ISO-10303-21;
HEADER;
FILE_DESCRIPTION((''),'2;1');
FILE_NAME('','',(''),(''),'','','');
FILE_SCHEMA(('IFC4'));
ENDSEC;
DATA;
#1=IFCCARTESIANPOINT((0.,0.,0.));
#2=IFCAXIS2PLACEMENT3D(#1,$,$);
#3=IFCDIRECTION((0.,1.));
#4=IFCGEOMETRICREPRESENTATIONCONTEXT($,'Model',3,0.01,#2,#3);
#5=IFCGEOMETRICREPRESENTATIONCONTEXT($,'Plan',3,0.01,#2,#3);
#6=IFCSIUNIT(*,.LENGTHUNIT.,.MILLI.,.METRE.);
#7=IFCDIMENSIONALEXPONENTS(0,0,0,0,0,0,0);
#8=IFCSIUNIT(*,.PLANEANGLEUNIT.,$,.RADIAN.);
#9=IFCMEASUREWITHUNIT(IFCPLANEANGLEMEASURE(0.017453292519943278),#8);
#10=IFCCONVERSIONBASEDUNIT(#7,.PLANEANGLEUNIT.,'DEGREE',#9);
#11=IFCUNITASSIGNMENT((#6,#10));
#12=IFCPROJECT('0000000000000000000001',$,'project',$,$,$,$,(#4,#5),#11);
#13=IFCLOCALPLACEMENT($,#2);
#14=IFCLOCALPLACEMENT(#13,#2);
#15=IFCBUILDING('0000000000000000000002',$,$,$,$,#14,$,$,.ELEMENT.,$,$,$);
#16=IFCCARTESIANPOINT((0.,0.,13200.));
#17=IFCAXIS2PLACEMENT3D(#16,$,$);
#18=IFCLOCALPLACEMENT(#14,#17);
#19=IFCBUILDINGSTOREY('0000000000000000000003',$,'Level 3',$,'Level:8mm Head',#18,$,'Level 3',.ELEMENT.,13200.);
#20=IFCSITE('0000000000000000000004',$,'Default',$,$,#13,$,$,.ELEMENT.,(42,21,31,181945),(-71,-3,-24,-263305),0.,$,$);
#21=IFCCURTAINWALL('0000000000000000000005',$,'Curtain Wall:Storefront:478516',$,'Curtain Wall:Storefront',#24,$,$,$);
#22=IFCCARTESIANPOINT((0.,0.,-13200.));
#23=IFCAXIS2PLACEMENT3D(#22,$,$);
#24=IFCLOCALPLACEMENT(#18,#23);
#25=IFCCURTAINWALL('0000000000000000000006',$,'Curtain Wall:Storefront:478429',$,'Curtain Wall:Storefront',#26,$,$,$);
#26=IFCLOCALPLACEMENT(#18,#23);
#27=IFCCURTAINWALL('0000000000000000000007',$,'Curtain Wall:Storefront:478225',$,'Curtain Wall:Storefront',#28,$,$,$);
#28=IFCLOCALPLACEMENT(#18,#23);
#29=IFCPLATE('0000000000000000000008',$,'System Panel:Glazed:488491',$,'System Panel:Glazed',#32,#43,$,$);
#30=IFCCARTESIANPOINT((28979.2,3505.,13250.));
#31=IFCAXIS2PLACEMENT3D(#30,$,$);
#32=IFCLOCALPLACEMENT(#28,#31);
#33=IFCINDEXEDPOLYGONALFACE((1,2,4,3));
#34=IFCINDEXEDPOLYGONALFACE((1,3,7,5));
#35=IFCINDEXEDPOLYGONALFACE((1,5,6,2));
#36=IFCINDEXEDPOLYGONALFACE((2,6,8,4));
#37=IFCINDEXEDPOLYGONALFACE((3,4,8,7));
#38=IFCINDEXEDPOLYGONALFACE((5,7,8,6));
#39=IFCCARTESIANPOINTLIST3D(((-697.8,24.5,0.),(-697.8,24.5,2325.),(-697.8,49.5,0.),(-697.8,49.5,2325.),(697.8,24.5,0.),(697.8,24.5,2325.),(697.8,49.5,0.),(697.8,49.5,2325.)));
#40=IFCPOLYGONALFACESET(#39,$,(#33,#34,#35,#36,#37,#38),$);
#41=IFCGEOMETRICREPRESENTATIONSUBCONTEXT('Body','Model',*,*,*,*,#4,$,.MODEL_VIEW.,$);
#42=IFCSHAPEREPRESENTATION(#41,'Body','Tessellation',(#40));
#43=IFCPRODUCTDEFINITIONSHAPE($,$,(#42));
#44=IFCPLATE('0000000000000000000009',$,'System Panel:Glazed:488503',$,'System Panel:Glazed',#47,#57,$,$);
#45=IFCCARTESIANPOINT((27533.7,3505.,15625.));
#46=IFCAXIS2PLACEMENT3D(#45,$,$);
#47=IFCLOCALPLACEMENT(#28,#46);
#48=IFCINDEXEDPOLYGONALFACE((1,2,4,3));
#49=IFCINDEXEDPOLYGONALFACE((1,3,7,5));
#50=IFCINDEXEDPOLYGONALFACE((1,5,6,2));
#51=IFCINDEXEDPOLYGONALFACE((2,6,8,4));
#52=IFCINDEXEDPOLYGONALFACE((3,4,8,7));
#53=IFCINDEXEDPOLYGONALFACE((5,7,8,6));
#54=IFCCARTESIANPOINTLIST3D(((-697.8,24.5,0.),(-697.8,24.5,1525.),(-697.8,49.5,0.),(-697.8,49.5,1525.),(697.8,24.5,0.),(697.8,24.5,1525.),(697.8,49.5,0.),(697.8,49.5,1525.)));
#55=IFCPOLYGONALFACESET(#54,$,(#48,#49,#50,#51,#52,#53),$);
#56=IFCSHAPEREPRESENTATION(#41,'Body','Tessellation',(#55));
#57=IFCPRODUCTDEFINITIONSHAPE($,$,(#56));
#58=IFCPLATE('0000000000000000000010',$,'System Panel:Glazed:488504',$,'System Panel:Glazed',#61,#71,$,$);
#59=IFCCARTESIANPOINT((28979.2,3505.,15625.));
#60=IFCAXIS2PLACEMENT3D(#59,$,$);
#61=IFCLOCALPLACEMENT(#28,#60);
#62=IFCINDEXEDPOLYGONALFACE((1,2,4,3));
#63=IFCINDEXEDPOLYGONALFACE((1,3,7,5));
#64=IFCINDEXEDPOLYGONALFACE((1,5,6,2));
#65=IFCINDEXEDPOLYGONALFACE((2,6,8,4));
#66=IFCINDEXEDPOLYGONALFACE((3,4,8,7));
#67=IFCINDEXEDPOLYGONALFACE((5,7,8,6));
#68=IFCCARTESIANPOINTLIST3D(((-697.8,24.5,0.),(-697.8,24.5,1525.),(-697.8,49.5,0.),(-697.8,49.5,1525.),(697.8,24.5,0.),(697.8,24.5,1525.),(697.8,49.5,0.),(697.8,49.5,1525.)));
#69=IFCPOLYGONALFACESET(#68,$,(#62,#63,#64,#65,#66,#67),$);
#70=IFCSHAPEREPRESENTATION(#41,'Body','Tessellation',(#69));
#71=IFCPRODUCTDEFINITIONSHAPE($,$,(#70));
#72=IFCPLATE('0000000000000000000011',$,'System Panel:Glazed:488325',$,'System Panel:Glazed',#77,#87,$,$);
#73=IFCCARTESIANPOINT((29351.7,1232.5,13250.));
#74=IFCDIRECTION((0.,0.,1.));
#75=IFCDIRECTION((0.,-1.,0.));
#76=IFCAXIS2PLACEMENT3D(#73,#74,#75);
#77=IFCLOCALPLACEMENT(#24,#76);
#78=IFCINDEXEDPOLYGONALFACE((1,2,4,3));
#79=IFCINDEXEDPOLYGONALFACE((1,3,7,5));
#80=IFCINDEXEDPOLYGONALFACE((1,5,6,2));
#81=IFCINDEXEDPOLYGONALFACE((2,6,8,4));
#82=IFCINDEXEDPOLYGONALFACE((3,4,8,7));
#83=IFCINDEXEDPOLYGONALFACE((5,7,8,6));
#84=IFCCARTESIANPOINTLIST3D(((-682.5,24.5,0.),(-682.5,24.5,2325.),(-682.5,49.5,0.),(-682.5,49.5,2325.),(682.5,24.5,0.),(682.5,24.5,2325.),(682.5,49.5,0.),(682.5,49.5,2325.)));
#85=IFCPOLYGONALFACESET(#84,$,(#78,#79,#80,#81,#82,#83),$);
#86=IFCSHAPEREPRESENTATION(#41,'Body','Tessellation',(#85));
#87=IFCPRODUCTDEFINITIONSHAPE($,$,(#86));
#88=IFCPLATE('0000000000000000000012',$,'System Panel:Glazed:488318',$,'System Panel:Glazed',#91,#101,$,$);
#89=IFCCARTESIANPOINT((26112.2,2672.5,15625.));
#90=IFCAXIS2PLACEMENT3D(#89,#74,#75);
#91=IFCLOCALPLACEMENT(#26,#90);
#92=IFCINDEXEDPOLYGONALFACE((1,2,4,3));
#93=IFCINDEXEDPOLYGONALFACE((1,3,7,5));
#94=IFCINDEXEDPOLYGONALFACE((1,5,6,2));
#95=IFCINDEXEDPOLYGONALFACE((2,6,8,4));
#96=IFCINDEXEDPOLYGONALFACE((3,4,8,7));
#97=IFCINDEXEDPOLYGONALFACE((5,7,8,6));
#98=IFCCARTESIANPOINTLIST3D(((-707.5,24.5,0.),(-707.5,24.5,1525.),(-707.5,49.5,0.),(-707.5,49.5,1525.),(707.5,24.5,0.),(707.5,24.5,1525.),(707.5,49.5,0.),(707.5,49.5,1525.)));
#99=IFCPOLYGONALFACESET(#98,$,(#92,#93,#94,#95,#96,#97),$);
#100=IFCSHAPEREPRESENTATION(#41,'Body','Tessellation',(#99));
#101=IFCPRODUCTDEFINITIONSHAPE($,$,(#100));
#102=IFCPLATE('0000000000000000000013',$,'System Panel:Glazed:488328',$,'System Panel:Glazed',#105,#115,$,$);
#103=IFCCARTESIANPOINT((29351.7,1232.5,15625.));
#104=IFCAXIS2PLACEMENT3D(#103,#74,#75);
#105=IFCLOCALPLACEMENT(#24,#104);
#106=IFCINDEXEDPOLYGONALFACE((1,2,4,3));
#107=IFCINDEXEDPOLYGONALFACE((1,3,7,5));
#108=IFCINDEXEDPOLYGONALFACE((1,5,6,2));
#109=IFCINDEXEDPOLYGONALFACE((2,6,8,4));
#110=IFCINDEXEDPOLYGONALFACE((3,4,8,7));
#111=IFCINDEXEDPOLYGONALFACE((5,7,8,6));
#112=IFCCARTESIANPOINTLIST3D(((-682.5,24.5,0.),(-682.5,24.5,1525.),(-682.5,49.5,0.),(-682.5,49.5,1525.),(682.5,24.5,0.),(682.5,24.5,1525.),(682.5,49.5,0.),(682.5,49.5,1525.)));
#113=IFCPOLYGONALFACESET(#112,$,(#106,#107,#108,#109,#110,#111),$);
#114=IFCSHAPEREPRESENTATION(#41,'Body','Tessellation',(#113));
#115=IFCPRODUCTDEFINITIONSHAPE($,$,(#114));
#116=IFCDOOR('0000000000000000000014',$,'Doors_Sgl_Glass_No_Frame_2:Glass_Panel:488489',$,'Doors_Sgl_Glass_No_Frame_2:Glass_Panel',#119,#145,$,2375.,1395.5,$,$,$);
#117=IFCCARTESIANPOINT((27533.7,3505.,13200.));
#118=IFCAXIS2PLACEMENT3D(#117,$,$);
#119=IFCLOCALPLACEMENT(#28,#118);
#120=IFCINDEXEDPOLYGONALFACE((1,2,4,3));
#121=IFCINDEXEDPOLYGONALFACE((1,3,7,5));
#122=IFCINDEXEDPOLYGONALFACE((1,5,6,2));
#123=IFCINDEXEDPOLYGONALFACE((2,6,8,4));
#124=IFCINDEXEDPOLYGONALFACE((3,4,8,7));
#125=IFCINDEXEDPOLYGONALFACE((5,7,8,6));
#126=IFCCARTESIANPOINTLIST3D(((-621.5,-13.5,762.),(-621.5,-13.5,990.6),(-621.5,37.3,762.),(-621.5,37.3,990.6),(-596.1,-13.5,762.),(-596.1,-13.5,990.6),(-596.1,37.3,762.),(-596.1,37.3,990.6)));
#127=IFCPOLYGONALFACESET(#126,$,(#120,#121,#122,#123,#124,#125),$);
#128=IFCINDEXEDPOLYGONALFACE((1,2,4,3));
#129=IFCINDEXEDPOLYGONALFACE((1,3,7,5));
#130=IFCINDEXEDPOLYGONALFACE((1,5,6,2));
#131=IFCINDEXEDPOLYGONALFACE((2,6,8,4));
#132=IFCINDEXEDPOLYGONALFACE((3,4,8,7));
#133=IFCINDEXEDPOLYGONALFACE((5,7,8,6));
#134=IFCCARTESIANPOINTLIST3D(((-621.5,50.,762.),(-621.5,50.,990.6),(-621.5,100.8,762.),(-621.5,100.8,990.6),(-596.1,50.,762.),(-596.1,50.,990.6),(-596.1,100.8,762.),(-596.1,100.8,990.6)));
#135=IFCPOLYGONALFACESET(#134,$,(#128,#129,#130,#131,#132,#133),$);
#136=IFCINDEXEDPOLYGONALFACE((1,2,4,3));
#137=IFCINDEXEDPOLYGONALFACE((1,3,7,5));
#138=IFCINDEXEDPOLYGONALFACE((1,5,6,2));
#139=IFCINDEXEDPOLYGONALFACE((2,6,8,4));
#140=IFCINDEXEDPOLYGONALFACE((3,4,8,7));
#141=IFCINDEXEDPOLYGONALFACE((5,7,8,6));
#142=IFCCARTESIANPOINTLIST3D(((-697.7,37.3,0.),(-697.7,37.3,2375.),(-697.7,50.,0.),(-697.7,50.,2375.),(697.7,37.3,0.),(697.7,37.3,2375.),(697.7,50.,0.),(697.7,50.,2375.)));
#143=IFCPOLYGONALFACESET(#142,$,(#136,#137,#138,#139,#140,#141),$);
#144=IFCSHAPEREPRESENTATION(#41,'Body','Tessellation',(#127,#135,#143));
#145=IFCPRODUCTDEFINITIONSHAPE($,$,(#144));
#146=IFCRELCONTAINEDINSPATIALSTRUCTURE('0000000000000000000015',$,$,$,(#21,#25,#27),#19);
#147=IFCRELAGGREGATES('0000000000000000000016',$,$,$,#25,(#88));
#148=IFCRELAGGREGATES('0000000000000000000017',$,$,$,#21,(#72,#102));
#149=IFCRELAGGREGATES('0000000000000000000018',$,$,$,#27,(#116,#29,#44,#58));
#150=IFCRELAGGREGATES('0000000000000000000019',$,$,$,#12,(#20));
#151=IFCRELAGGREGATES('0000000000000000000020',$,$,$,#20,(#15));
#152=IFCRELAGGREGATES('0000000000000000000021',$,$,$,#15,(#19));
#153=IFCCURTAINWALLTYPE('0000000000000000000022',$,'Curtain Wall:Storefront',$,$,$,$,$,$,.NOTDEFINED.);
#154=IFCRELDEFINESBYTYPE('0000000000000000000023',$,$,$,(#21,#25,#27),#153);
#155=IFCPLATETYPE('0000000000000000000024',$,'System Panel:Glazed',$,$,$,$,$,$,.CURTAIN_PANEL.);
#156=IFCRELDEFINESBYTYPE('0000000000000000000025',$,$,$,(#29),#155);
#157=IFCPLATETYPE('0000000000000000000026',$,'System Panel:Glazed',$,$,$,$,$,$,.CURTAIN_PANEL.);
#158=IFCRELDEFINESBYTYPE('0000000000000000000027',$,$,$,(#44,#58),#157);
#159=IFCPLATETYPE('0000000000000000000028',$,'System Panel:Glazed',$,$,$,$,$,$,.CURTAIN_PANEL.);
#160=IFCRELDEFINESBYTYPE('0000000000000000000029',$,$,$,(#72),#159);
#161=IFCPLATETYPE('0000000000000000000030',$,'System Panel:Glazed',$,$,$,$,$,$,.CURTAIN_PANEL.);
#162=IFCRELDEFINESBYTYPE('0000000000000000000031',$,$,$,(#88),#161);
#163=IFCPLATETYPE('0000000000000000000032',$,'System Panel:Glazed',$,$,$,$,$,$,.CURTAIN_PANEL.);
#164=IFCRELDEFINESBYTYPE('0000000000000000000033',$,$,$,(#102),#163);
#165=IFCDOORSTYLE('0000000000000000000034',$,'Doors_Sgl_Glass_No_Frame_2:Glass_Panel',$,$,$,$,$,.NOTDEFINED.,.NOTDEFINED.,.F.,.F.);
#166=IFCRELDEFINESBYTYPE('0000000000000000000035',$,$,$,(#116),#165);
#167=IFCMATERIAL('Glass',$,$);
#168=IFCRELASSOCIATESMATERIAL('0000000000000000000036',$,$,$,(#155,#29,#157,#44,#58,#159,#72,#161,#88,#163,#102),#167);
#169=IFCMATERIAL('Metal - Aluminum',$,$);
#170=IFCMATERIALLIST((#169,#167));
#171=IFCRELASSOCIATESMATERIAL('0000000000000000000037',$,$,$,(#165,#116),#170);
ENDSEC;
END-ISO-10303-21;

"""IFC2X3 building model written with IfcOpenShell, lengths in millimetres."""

from ifc_helpers import new_model, entity, si_unit, converted_unit, direction, frame, frame_2d, origin, origin_2d_with_axis, place, context, subcontext, project, spatial, rectangle, extrude, source, transform, mapped, material, material_list, type_object, type_shapes, element, aggregate, save


model = new_model("IFC2X3")

# Units and contexts
model_context = context("Model", 3, precision=0.01, world=origin(), true_north=direction((0.0, 1.0)))
plan_context = context("Plan", 3, precision=0.01, world=origin(), true_north=direction((0.0, 1.0)))
body_context = subcontext(model_context, "Body", "Model", "MODEL_VIEW")
ifc_project = project(units=[si_unit("LENGTHUNIT", "METRE", prefix="MILLI"), converted_unit("PLANEANGLEUNIT", "DEGREE", entity("IfcPlaneAngleMeasure", 0.017453292519943278), si_unit("PLANEANGLEUNIT", "RADIAN"), dimensions=[0, 0, 0, 0, 0, 0, 0])], contexts=[model_context, plan_context])

# Site, building, storey
site_placement = place(None, origin())
site = spatial("IfcSite", under=ifc_project, at=site_placement, Name="Default", CompositionType="ELEMENT", RefLatitude=(42, 21, 31, 181945), RefLongitude=(-71, -3, -24, -263305), RefElevation=0.0)
building_placement = place(site_placement, origin())
building = spatial("IfcBuilding", under=site, at=building_placement, CompositionType="ELEMENT")
storey_placement = place(building_placement, frame((0.0, 0.0, 13200.0)))
storey = spatial("IfcBuildingStorey", under=building, at=storey_placement, Name="Level 3", ObjectType="Level:8mm Head", LongName="Level 3", CompositionType="ELEMENT", Elevation=13200.0)

# Curtain walls
curtain_wall_type = type_object("IfcCurtainWallType", Name="Curtain Wall:Storefront", PredefinedType="NOTDEFINED")
curtain_wall_1_placement = place(storey_placement, frame((0.0, 0.0, -13200.0)))
curtain_wall_1 = element("IfcCurtainWall", 1, at=curtain_wall_1_placement, inside=storey, type_object=curtain_wall_type, Name="Curtain Wall:Storefront:478516", ObjectType="Curtain Wall:Storefront")
curtain_wall_2_placement = place(storey_placement, frame((0.0, 0.0, -13200.0)))
curtain_wall_2 = element("IfcCurtainWall", 2, at=curtain_wall_2_placement, inside=storey, type_object=curtain_wall_type, Name="Curtain Wall:Storefront:478429", ObjectType="Curtain Wall:Storefront")

# Curtain wall
curtain_wall_3_placement = place(storey_placement, frame((0.0, 0.0, -13200.0)))
curtain_wall_3 = element("IfcCurtainWall", 3, at=curtain_wall_3_placement, inside=storey, type_object=curtain_wall_type, Name="Curtain Wall:Storefront:478225", ObjectType="Curtain Wall:Storefront")

# Plates
ifc_material_1 = material(Name="Glass")
plate_type_1 = type_object("IfcPlateType", Name="System Panel:Glazed", PredefinedType="CURTAIN_PANEL", material=ifc_material_1)
shared_shape_1 = source(origin(), body_context, "Body", "SweptSolid", [
    extrude(rectangle(XDim=25.0, YDim=1395.5, at=origin_2d_with_axis()), frame((0.0, 37.0, 0.0), z_axis=(0.0, 0.0, 1.0), x_axis=(0.0, 1.0, 0.0)), (0.0, 0.0, 1.0), 2325.0),
])
type_shapes(plate_type_1, [shared_shape_1])
plate_1_placement = place(curtain_wall_3_placement, frame((28979.2, 3505.0, 13250.0)))
plate_1 = element("IfcPlate", 4, at=plate_1_placement, type_object=plate_type_1, material=ifc_material_1, Name="System Panel:Glazed:488491", ObjectType="System Panel:Glazed", context=body_context, shape_type="MappedRepresentation", body=[
    mapped(shared_shape_1, transform((0.0, 0.0, 0.0), scale=1.0)),
])
plate_type_2 = type_object("IfcPlateType", Name="System Panel:Glazed", PredefinedType="CURTAIN_PANEL", material=ifc_material_1)
shared_shape_2 = source(origin(), body_context, "Body", "SweptSolid", [
    extrude(rectangle(XDim=25.0, YDim=1395.5, at=origin_2d_with_axis()), frame((0.0, 37.0, 0.0), z_axis=(0.0, 0.0, 1.0), x_axis=(0.0, 1.0, 0.0)), (0.0, 0.0, 1.0), 1525.0),
])
type_shapes(plate_type_2, [shared_shape_2])
plate_2_placement = place(curtain_wall_3_placement, frame((27533.7, 3505.0, 15625.0)))
plate_2 = element("IfcPlate", 5, at=plate_2_placement, type_object=plate_type_2, material=ifc_material_1, Name="System Panel:Glazed:488503", ObjectType="System Panel:Glazed", context=body_context, shape_type="MappedRepresentation", body=[
    mapped(shared_shape_2, transform((0.0, 0.0, 0.0), scale=1.0)),
])
plate_3_placement = place(curtain_wall_3_placement, frame((28979.2, 3505.0, 15625.0)))
plate_3 = element("IfcPlate", 6, at=plate_3_placement, type_object=plate_type_2, material=ifc_material_1, Name="System Panel:Glazed:488504", ObjectType="System Panel:Glazed", context=body_context, shape_type="MappedRepresentation", body=[
    mapped(shared_shape_2, transform((0.0, 0.0, 0.0), scale=1.0)),
])
plate_type_3 = type_object("IfcPlateType", Name="System Panel:Glazed", PredefinedType="CURTAIN_PANEL", material=ifc_material_1)
shared_shape_3 = source(origin(), body_context, "Body", "SweptSolid", [
    extrude(rectangle(XDim=25.0, YDim=1365.0, at=origin_2d_with_axis()), frame((0.0, 37.0, 0.0), z_axis=(0.0, 0.0, 1.0), x_axis=(0.0, 1.0, 0.0)), (0.0, 0.0, 1.0), 2325.0),
])
type_shapes(plate_type_3, [shared_shape_3])
plate_4_placement = place(curtain_wall_1_placement, frame((29351.7, 1232.5, 13250.0), z_axis=(0.0, 0.0, 1.0), x_axis=(0.0, -1.0, 0.0)))
plate_4 = element("IfcPlate", 7, at=plate_4_placement, type_object=plate_type_3, material=ifc_material_1, Name="System Panel:Glazed:488325", ObjectType="System Panel:Glazed", context=body_context, shape_type="MappedRepresentation", body=[
    mapped(shared_shape_3, transform((0.0, 0.0, 0.0), scale=1.0)),
])
plate_type_4 = type_object("IfcPlateType", Name="System Panel:Glazed", PredefinedType="CURTAIN_PANEL", material=ifc_material_1)
shared_shape_4 = source(origin(), body_context, "Body", "SweptSolid", [
    extrude(rectangle(XDim=25.0, YDim=1415.0, at=origin_2d_with_axis()), frame((0.0, 37.0, 0.0), z_axis=(0.0, 0.0, 1.0), x_axis=(0.0, 1.0, 0.0)), (0.0, 0.0, 1.0), 1525.0),
])
type_shapes(plate_type_4, [shared_shape_4])
plate_5_placement = place(curtain_wall_2_placement, frame((26112.2, 2672.5, 15625.0), z_axis=(0.0, 0.0, 1.0), x_axis=(0.0, -1.0, 0.0)))
plate_5 = element("IfcPlate", 8, at=plate_5_placement, type_object=plate_type_4, material=ifc_material_1, Name="System Panel:Glazed:488318", ObjectType="System Panel:Glazed", context=body_context, shape_type="MappedRepresentation", body=[
    mapped(shared_shape_4, transform((0.0, 0.0, 0.0), scale=1.0)),
])
aggregate(curtain_wall_2, [plate_5])
plate_type_5 = type_object("IfcPlateType", Name="System Panel:Glazed", PredefinedType="CURTAIN_PANEL", material=ifc_material_1)
shared_shape_5 = source(origin(), body_context, "Body", "SweptSolid", [
    extrude(rectangle(XDim=25.0, YDim=1365.0, at=origin_2d_with_axis()), frame((0.0, 37.0, 0.0), z_axis=(0.0, 0.0, 1.0), x_axis=(0.0, 1.0, 0.0)), (0.0, 0.0, 1.0), 1525.0),
])
type_shapes(plate_type_5, [shared_shape_5])
plate_6_placement = place(curtain_wall_1_placement, frame((29351.7, 1232.5, 15625.0), z_axis=(0.0, 0.0, 1.0), x_axis=(0.0, -1.0, 0.0)))
plate_6 = element("IfcPlate", 9, at=plate_6_placement, type_object=plate_type_5, material=ifc_material_1, Name="System Panel:Glazed:488328", ObjectType="System Panel:Glazed", context=body_context, shape_type="MappedRepresentation", body=[
    mapped(shared_shape_5, transform((0.0, 0.0, 0.0), scale=1.0)),
])
aggregate(curtain_wall_1, [plate_4, plate_6])

# Door
ifc_material_2 = material(Name="Metal - Aluminum")
ifc_material_list = material_list([ifc_material_2, ifc_material_1])
door_style = type_object("IfcDoorStyle", Name="Doors_Sgl_Glass_No_Frame_2:Glass_Panel", ConstructionType="NOTDEFINED", OperationType="NOTDEFINED", ParameterTakesPrecedence=False, Sizeable=False, material=ifc_material_list)
shared_shape_6 = source(origin(), body_context, "Body", "SweptSolid", [
    extrude(rectangle(XDim=50.8, YDim=25.4, at=origin_2d_with_axis()), frame((-608.8, 11.9, 762.0), z_axis=(0.0, 0.0, 1.0), x_axis=(0.0, 1.0, 0.0)), (0.0, 0.0, 1.0), 228.6),
    extrude(rectangle(XDim=50.8, YDim=25.4, at=origin_2d_with_axis()), frame((-608.8, 75.4, 762.0), z_axis=(0.0, 0.0, 1.0), x_axis=(0.0, -1.0, 0.0)), (0.0, 0.0, 1.0), 228.6),
    extrude(rectangle(XDim=1395.5, YDim=12.7, at=frame_2d((0.0, 0.0), x_axis=(1.0, 0.0))), frame((0.0, 43.7, 0.0), z_axis=(0.0, 0.0, 1.0), x_axis=(-1.0, 0.0, 0.0)), (0.0, 0.0, 1.0), 2375.0),
])
type_shapes(door_style, [shared_shape_6])
door_placement = place(curtain_wall_3_placement, frame((27533.7, 3505.0, 13200.0)))
door = element("IfcDoor", 10, at=door_placement, type_object=door_style, material=ifc_material_list, Name="Doors_Sgl_Glass_No_Frame_2:Glass_Panel:488489", ObjectType="Doors_Sgl_Glass_No_Frame_2:Glass_Panel", OverallHeight=2375.0, OverallWidth=1395.5, context=body_context, shape_type="MappedRepresentation", body=[
    mapped(shared_shape_6, transform((0.0, 0.0, 0.0), scale=1.0)),
])
aggregate(curtain_wall_3, [door, plate_1, plate_2, plate_3])

save(model, "model.ifc")
